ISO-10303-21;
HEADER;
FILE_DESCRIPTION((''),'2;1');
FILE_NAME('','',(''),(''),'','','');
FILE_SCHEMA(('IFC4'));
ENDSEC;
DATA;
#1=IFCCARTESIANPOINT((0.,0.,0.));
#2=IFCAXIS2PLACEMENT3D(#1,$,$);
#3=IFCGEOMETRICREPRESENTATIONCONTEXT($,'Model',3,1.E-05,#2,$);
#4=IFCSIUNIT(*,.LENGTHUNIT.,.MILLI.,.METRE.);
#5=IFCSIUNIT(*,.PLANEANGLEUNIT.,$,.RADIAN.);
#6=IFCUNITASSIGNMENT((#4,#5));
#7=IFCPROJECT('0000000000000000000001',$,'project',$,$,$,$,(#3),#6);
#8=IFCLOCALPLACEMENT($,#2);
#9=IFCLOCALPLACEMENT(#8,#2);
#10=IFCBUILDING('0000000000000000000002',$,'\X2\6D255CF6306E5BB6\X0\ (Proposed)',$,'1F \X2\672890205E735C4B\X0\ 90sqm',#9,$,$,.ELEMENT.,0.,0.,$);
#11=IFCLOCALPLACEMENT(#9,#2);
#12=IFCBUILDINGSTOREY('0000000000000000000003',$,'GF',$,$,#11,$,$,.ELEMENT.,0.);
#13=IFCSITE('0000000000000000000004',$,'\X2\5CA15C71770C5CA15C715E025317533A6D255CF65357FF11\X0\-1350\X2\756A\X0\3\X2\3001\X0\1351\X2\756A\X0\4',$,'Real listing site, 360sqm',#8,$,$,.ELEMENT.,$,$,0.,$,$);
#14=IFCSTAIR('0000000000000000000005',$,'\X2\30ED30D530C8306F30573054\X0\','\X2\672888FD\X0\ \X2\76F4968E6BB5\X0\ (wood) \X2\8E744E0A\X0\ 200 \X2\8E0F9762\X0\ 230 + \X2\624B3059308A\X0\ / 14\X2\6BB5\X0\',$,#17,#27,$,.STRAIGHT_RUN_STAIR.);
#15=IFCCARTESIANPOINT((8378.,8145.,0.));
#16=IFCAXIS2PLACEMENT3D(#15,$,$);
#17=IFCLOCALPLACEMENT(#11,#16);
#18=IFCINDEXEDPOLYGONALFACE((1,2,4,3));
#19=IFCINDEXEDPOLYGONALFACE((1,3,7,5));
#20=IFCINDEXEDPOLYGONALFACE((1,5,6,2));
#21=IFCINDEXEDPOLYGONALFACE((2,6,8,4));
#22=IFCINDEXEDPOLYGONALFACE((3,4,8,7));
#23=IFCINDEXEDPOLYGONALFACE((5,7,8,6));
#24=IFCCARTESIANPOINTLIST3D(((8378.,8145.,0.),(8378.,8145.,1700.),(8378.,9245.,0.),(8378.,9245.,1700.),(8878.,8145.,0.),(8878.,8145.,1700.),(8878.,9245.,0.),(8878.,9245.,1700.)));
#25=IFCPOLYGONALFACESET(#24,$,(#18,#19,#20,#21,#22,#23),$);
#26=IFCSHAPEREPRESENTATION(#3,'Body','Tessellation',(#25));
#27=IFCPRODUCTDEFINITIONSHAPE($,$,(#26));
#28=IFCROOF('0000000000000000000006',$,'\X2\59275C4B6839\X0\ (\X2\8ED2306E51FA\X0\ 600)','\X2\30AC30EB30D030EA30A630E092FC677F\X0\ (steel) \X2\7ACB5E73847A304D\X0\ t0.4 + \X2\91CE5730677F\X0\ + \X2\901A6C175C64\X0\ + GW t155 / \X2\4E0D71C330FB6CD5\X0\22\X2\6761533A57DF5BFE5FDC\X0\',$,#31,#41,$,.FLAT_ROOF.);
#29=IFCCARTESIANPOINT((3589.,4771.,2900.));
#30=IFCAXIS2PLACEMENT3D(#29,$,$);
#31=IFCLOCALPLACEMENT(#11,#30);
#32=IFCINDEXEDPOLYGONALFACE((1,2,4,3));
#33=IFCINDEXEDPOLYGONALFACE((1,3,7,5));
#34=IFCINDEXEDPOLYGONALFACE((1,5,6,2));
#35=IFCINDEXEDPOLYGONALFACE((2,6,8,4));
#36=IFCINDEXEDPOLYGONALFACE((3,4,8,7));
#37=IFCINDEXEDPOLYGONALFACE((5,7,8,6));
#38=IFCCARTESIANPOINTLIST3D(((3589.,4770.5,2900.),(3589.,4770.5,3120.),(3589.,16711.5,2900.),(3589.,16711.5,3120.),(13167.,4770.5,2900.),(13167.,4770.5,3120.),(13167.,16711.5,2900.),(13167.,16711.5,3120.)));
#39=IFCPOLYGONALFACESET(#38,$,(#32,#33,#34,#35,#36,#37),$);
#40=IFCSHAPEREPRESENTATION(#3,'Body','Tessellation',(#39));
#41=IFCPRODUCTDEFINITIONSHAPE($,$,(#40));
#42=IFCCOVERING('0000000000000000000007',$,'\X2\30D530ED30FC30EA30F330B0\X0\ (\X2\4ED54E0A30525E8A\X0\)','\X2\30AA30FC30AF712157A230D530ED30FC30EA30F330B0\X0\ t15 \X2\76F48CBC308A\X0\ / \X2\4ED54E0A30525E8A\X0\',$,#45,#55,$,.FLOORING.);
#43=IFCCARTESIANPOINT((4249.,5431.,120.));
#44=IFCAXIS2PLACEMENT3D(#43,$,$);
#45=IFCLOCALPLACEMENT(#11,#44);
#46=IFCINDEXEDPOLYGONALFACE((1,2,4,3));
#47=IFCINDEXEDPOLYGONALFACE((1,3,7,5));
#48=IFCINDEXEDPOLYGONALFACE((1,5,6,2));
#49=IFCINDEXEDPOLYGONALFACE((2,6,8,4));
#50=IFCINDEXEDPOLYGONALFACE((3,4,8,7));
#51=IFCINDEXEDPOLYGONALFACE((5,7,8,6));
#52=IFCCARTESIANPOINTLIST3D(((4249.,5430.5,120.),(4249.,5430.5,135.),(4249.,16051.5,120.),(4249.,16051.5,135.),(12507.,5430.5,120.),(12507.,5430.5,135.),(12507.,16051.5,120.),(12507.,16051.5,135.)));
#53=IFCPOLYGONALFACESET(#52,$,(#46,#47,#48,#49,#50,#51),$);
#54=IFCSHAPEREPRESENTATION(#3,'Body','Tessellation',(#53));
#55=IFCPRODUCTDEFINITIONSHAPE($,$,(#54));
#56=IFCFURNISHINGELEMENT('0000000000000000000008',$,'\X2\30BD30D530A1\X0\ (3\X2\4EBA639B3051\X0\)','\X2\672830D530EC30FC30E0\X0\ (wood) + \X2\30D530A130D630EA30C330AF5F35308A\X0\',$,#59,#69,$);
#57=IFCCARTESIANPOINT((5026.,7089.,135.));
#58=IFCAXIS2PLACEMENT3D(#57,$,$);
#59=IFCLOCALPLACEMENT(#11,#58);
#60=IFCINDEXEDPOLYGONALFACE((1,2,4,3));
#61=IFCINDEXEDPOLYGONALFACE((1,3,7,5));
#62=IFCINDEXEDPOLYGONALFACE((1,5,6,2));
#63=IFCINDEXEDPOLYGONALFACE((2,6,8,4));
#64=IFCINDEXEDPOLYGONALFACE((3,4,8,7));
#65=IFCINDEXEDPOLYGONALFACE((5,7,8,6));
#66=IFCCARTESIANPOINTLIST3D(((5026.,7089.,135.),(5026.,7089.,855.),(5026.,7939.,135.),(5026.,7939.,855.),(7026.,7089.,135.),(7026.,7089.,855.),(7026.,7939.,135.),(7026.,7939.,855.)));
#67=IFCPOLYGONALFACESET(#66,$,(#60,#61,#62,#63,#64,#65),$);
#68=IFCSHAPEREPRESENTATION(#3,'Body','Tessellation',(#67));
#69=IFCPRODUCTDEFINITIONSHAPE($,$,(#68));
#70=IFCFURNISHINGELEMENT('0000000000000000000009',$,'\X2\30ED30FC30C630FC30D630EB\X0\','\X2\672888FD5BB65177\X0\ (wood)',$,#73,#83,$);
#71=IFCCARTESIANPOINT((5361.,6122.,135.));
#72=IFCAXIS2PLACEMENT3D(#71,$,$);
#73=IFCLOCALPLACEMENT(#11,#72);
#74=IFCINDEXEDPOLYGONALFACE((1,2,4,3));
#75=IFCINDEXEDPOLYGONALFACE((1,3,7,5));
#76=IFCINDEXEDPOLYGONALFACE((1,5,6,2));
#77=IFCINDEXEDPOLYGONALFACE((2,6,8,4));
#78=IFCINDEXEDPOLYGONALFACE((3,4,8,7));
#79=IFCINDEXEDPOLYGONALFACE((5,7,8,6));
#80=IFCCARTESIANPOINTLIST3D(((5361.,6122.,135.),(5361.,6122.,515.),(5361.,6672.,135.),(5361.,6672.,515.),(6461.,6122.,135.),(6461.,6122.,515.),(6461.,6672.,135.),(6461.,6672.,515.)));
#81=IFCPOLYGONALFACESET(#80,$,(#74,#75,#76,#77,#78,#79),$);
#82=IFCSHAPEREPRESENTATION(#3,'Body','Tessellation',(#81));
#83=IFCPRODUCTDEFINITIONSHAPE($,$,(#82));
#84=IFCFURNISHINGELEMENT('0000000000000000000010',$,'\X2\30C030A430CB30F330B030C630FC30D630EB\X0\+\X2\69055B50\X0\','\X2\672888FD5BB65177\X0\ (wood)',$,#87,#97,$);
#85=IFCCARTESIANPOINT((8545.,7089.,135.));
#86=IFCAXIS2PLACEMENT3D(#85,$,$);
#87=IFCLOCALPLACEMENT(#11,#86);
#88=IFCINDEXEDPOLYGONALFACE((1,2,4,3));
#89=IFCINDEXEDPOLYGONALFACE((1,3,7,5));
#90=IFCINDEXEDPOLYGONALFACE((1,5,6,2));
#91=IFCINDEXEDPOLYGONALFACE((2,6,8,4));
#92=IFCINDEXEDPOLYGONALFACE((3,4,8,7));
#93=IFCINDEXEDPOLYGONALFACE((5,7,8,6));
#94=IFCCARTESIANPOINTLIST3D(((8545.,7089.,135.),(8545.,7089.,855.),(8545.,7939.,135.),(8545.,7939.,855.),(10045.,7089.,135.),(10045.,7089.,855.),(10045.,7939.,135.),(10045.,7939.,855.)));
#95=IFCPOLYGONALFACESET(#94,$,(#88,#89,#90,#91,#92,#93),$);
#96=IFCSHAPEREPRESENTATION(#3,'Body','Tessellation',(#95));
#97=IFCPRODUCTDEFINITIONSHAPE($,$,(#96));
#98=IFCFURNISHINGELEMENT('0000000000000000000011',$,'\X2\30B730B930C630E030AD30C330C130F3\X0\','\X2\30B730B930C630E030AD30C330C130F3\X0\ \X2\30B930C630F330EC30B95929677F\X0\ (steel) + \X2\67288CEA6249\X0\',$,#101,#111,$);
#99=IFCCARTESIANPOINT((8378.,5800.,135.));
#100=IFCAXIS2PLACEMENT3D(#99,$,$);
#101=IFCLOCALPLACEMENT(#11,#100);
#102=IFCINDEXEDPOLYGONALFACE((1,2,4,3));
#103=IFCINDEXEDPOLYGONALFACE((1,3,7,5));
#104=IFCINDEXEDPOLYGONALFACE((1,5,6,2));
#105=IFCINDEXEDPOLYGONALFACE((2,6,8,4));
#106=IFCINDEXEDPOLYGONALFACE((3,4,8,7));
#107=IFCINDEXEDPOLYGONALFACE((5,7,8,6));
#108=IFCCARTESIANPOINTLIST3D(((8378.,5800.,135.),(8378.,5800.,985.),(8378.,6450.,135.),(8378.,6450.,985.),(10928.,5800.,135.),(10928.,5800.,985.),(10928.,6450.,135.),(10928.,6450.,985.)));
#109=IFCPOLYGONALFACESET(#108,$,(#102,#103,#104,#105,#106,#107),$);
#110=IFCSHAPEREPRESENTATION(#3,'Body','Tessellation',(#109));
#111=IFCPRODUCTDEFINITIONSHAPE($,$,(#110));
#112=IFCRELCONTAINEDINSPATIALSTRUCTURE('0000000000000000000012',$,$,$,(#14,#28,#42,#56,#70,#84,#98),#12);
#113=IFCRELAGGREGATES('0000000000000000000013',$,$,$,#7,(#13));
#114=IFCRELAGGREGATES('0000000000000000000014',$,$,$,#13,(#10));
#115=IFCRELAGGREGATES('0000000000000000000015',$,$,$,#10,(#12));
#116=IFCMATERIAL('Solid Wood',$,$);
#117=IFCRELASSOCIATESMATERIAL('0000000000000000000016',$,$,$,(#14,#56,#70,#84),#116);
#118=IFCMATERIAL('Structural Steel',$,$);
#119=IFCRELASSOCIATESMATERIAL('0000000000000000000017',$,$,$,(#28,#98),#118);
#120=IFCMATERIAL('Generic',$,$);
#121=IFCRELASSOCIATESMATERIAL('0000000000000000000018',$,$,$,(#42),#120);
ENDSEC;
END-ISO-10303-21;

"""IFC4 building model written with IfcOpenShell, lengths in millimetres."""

from ifc_helpers import new_model, si_unit, frame, frame_2d, origin, place, context, project, spatial, rectangle, extrude, material, element, save


model = new_model("IFC4")

# Units and contexts
model_context = context("Model", 3, precision=1e-05, world=origin())
ifc_project = project(units=[si_unit("LENGTHUNIT", "METRE", prefix="MILLI"), si_unit("PLANEANGLEUNIT", "RADIAN")], contexts=[model_context])

# Site, building, storey
site_placement = place(None, origin())
site = spatial("IfcSite", under=ifc_project, at=site_placement, Name="岡山県岡山市北区津島南１-1350番3、1351番4", ObjectType="Real listing site, 360sqm", CompositionType="ELEMENT", RefElevation=0.0)
building_placement = place(site_placement, origin())
building = spatial("IfcBuilding", under=site, at=building_placement, Name="津島の家 (Proposed)", ObjectType="1F 木造平屋 90sqm", CompositionType="ELEMENT", ElevationOfRefHeight=0.0, ElevationOfTerrain=0.0)
storey_placement = place(building_placement, origin())
storey = spatial("IfcBuildingStorey", under=building, at=storey_placement, Name="GF", CompositionType="ELEMENT", Elevation=0.0)

# Shared definitions
ifc_material_1 = material(Name="Solid Wood")

# Stair
stair_placement = place(storey_placement, frame((8378.0, 8145.0, 0.0)))
element("IfcStair", 1, at=stair_placement, inside=storey, material=ifc_material_1, Name="ロフトはしご", Description="木製 直階段 (wood) 蹴上 200 踏面 230 + 手すり / 14段", PredefinedType="STRAIGHT_RUN_STAIR", context=model_context, shape_type="SweptSolid", body=[
    extrude(rectangle(XDim=500.0, YDim=1100.0, at=frame_2d((250.0, 550.0))), frame((8378.0, 8145.0, 0.0)), (0.0, 0.0, 1.0), 1700.0),
])

# Roof
ifc_material_2 = material(Name="Structural Steel")
roof_placement = place(storey_placement, frame((3589.0, 4771.0, 2900.0)))
element("IfcRoof", 2, at=roof_placement, inside=storey, material=ifc_material_2, Name="大屋根 (軒の出 600)", Description="ガルバリウム鋼板 (steel) 立平葺き t0.4 + 野地板 + 通気層 + GW t155 / 不燃・法22条区域対応", PredefinedType="FLAT_ROOF", context=model_context, shape_type="SweptSolid", body=[
    extrude(rectangle(XDim=9578.0, YDim=11941.0, at=frame_2d((4789.0, 5970.0))), frame((3589.0, 4771.0, 2900.0)), (0.0, 0.0, 1.0), 220.0),
])

# Covering
ifc_material_3 = material(Name="Generic")
covering_placement = place(storey_placement, frame((4249.0, 5431.0, 120.0)))
element("IfcCovering", 3, at=covering_placement, inside=storey, material=ifc_material_3, Name="フローリング (仕上げ床)", Description="オーク無垢フローリング t15 直貼り / 仕上げ床", PredefinedType="FLOORING", context=model_context, shape_type="SweptSolid", body=[
    extrude(rectangle(XDim=8258.0, YDim=10621.0, at=frame_2d((4129.0, 5310.0))), frame((4249.0, 5431.0, 120.0)), (0.0, 0.0, 1.0), 15.0),
])

# Furnishing elements
furnishing_1_placement = place(storey_placement, frame((5026.0, 7089.0, 135.0)))
element("IfcFurnishingElement", 4, at=furnishing_1_placement, inside=storey, material=ifc_material_1, Name="ソファ (3人掛け)", Description="木フレーム (wood) + ファブリック張り", context=model_context, shape_type="SweptSolid", body=[
    extrude(rectangle(XDim=2000.0, YDim=850.0, at=frame_2d((1000.0, 425.0))), frame((5026.0, 7089.0, 135.0)), (0.0, 0.0, 1.0), 720.0),
])
furnishing_2_placement = place(storey_placement, frame((5361.0, 6122.0, 135.0)))
element("IfcFurnishingElement", 5, at=furnishing_2_placement, inside=storey, material=ifc_material_1, Name="ローテーブル", Description="木製家具 (wood)", context=model_context, shape_type="SweptSolid", body=[
    extrude(rectangle(XDim=1100.0, YDim=550.0, at=frame_2d((550.0, 275.0))), frame((5361.0, 6122.0, 135.0)), (0.0, 0.0, 1.0), 380.0),
])
furnishing_3_placement = place(storey_placement, frame((8545.0, 7089.0, 135.0)))
element("IfcFurnishingElement", 6, at=furnishing_3_placement, inside=storey, material=ifc_material_1, Name="ダイニングテーブル+椅子", Description="木製家具 (wood)", context=model_context, shape_type="SweptSolid", body=[
    extrude(rectangle(XDim=1500.0, YDim=850.0, at=frame_2d((750.0, 425.0))), frame((8545.0, 7089.0, 135.0)), (0.0, 0.0, 1.0), 720.0),
])
furnishing_4_placement = place(storey_placement, frame((8378.0, 5800.0, 135.0)))
element("IfcFurnishingElement", 7, at=furnishing_4_placement, inside=storey, material=ifc_material_2, Name="システムキッチン", Description="システムキッチン ステンレス天板 (steel) + 木質扉", context=model_context, shape_type="SweptSolid", body=[
    extrude(rectangle(XDim=2550.0, YDim=650.0, at=frame_2d((1275.0, 325.0))), frame((8378.0, 5800.0, 135.0)), (0.0, 0.0, 1.0), 850.0),
])

save(model, "model.ifc")
